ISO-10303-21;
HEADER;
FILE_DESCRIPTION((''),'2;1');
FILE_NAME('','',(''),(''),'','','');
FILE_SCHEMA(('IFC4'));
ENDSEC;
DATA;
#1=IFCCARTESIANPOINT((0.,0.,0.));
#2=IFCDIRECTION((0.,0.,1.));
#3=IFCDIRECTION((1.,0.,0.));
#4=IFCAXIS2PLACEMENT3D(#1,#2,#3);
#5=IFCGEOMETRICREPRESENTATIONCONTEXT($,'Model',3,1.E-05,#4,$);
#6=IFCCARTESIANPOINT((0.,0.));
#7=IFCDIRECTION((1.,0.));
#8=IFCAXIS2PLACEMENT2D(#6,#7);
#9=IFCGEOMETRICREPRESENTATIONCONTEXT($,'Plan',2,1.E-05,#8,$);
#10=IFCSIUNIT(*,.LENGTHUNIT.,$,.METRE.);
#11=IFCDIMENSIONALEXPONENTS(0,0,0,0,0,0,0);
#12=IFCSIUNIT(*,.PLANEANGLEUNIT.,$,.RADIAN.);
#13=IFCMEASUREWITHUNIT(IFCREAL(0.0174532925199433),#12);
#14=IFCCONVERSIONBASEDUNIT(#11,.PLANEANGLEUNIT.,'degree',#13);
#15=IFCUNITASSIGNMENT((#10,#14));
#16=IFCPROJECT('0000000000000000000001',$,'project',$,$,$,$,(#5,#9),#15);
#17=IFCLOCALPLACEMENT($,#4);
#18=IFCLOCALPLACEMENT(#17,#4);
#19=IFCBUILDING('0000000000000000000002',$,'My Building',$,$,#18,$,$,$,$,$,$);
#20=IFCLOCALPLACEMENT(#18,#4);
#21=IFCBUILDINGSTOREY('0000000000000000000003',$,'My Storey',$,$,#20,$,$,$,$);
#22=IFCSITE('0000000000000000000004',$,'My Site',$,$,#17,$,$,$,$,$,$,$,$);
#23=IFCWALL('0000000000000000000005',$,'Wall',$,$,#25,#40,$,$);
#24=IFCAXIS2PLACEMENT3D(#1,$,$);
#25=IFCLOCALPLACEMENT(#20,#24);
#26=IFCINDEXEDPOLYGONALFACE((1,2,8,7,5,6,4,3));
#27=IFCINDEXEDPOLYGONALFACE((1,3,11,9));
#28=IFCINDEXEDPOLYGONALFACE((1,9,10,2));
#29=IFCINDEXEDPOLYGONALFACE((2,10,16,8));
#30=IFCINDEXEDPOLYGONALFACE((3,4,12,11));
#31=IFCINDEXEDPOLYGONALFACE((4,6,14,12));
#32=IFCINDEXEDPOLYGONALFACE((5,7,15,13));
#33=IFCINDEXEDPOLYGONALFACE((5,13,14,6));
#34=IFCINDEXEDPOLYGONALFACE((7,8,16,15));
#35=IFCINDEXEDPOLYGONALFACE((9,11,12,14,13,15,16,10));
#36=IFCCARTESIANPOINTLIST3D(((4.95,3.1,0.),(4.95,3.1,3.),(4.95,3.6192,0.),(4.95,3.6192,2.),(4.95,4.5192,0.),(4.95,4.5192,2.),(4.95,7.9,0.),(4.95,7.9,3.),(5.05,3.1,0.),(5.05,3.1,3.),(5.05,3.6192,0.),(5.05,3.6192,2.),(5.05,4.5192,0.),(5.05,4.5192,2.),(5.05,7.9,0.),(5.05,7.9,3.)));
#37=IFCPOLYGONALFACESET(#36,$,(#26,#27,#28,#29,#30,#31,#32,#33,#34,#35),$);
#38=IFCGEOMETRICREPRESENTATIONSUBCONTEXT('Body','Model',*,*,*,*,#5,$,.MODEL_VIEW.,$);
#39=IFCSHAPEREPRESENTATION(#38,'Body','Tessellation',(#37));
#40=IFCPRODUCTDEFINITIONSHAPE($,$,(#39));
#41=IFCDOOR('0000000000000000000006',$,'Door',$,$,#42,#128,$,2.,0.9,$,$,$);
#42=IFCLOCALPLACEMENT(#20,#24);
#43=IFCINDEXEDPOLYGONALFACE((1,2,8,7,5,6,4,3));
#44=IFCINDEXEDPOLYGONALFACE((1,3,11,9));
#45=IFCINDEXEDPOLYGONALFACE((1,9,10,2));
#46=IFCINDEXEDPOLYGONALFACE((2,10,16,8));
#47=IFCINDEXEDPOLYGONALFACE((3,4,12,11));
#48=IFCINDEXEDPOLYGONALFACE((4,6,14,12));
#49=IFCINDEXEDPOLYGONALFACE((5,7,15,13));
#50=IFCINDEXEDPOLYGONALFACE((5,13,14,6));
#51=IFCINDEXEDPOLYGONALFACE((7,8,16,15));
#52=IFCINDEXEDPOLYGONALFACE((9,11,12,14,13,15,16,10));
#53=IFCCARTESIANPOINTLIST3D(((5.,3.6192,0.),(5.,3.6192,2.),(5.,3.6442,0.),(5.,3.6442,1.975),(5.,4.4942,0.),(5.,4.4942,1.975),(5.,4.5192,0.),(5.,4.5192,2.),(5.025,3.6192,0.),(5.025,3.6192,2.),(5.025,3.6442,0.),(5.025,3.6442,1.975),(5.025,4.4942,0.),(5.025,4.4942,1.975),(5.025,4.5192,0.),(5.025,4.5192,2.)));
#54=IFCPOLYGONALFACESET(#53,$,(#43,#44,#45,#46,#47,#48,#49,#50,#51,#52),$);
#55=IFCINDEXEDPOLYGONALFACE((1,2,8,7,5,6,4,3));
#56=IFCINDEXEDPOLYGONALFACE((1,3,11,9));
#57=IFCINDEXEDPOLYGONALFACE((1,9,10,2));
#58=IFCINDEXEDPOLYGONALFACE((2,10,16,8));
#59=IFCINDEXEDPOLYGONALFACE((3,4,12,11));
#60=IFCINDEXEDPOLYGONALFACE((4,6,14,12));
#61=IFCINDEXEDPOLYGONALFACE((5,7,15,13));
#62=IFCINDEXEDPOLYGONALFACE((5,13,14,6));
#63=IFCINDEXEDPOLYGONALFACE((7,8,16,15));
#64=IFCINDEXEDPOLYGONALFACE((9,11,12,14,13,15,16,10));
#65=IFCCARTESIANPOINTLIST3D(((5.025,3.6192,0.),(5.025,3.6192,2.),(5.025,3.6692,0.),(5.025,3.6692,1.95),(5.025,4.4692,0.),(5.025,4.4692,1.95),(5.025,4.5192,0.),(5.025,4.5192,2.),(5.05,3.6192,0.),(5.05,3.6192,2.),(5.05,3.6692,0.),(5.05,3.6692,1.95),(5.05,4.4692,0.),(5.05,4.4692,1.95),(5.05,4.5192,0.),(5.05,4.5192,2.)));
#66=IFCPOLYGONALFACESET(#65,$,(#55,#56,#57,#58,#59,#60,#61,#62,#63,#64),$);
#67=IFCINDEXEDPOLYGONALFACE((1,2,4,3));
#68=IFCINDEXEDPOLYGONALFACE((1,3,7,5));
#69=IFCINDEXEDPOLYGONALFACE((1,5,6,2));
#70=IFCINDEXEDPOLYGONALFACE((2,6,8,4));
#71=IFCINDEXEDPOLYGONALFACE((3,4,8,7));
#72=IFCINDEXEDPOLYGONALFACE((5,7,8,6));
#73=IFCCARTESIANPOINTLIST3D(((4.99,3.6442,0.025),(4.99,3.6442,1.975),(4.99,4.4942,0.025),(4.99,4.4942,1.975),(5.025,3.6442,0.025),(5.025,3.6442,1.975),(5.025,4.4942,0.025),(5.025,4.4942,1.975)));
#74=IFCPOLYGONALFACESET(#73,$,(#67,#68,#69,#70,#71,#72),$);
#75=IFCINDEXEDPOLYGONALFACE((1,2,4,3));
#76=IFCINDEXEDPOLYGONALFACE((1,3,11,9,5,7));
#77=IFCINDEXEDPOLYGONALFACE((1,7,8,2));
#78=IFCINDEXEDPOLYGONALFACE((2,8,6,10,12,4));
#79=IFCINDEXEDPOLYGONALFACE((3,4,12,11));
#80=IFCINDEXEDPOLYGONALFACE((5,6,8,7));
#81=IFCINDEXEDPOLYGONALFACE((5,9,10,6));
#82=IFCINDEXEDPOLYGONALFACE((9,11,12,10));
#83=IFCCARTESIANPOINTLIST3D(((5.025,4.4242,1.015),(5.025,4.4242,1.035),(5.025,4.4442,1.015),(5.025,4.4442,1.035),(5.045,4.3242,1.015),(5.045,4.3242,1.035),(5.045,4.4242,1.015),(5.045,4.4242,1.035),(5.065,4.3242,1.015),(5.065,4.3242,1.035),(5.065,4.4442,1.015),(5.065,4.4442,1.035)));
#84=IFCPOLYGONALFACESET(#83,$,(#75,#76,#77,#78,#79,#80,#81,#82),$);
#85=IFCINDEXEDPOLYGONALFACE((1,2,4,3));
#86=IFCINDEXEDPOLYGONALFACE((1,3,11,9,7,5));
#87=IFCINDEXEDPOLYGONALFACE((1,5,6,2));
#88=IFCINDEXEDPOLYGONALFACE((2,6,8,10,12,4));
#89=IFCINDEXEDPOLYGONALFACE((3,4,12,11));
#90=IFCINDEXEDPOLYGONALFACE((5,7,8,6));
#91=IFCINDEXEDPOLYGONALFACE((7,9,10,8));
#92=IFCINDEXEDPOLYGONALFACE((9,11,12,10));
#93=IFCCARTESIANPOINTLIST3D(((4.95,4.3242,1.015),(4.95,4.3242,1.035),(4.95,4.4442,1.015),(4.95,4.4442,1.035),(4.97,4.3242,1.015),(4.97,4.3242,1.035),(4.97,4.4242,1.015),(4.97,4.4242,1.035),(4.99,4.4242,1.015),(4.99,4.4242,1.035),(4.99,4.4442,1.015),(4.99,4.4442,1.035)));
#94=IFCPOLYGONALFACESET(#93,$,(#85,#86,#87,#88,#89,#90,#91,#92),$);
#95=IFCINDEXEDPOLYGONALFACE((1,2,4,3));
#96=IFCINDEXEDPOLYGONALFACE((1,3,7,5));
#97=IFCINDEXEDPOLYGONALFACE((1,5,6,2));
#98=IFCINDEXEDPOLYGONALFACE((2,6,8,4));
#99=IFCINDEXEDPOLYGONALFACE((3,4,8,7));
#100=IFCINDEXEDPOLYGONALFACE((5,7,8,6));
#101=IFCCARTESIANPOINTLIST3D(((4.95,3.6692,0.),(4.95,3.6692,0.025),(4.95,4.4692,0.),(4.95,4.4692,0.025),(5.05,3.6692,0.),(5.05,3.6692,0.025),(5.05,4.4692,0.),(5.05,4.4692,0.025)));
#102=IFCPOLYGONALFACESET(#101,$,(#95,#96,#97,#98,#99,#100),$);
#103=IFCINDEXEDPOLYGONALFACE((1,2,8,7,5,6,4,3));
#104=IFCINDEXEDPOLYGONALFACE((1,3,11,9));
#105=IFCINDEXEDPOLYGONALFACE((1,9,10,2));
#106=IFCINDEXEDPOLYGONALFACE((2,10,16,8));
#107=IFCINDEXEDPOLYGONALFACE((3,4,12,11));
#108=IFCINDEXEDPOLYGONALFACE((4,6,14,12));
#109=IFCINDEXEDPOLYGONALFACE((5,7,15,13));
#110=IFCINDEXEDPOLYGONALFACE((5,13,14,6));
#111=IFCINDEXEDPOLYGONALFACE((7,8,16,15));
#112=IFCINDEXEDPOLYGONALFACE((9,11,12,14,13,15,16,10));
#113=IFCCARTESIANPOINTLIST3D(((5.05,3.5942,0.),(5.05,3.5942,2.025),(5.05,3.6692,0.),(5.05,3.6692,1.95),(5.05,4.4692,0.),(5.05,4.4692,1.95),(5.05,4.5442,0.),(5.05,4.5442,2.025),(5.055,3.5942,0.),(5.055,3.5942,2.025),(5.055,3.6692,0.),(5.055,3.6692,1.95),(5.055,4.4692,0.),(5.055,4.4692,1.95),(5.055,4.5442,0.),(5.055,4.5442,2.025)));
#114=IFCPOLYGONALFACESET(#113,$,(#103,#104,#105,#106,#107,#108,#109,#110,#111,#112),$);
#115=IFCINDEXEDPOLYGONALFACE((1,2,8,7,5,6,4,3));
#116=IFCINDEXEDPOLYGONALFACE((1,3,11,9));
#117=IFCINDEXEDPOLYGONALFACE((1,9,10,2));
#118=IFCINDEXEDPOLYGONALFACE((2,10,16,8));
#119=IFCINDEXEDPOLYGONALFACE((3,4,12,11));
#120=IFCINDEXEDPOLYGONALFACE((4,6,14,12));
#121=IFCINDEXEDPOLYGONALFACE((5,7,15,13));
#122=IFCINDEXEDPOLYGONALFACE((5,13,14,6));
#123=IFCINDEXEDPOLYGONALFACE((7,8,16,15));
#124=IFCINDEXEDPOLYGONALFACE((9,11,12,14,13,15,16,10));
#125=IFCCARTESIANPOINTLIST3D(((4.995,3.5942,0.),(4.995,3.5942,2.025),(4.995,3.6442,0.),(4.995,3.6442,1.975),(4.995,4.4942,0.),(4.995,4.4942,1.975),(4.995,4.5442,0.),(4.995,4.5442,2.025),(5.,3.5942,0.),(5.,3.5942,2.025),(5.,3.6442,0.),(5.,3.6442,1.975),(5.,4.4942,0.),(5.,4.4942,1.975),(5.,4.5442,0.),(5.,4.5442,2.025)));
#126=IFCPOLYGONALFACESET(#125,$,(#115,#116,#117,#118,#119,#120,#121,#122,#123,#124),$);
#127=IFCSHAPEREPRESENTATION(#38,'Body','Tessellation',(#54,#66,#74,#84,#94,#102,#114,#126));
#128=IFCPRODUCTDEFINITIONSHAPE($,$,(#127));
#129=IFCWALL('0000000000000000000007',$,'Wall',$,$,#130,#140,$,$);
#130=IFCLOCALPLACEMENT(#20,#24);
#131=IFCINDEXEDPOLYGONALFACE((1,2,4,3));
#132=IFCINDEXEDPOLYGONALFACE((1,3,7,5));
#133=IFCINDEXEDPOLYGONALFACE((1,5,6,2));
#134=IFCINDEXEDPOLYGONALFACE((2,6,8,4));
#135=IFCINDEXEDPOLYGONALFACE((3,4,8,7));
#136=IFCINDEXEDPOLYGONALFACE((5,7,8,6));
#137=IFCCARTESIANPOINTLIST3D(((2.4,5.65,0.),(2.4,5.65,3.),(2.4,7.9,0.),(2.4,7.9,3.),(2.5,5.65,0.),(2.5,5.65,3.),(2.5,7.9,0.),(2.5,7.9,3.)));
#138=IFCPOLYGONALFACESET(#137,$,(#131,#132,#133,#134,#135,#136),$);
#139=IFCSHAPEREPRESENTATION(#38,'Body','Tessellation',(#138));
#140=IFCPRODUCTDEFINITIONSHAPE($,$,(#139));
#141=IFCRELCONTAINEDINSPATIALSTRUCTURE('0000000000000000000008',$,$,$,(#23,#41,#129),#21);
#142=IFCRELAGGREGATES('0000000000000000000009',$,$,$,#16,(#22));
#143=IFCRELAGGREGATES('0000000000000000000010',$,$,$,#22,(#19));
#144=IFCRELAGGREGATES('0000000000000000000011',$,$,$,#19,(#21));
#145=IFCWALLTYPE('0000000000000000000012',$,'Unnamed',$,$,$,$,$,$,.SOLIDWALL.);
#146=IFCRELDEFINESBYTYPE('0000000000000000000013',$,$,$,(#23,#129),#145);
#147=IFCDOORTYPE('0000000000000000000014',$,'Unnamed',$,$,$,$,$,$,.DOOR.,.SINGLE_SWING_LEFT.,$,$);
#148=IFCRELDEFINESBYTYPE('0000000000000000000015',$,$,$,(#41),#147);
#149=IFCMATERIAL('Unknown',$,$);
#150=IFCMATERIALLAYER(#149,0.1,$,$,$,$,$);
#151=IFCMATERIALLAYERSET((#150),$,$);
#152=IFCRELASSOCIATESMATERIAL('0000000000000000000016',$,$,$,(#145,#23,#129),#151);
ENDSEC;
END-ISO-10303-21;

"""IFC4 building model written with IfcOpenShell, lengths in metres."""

from ifc_helpers import new_model, entity, si_unit, converted_unit, frame, origin_with_axes, origin_2d_with_axis, place, context, subcontext, project, spatial, line, indexed_curve, outline, extrude, shape, source, transform, mapped, material, layer, layer_set, layer_usage, type_object, type_shapes, element, fill, save


model = new_model("IFC4")

# Units and contexts
model_context = context("Model", 3, precision=1e-05, world=origin_with_axes())
plan_context = context("Plan", 2, precision=1e-05, world=origin_2d_with_axis())
body_context_1 = subcontext(model_context, "Body", "Model", "MODEL_VIEW")
body_context_2 = subcontext(plan_context, "Body", "Plan", "PLAN_VIEW")
ifc_project = project(units=[si_unit("LENGTHUNIT", "METRE"), converted_unit("PLANEANGLEUNIT", "degree", entity("IfcReal", 0.0174532925199433), si_unit("PLANEANGLEUNIT", "RADIAN"), dimensions=[0, 0, 0, 0, 0, 0, 0])], contexts=[model_context, plan_context])

# Site, building, storey
site_placement = place(None, origin_with_axes())
site = spatial("IfcSite", under=ifc_project, at=site_placement, Name="My Site")
building_placement = place(site_placement, origin_with_axes())
building = spatial("IfcBuilding", under=site, at=building_placement, Name="My Building")
storey_placement = place(building_placement, origin_with_axes())
storey = spatial("IfcBuildingStorey", under=building, at=storey_placement, Name="My Storey")

# Shared definitions
ifc_material = material(Name="Unknown")

# Shared definitions
ifc_layer = layer(ifc_material, 0.1)
ifc_layer_set = layer_set([ifc_layer])
wall_type = type_object("IfcWallType", Name="Unnamed", PredefinedType="SOLIDWALL", material=ifc_layer_set)
shared_shape_1 = source(origin_with_axes(), body_context_1, "Body", "SweptSolid", [
    extrude(outline(indexed_curve([(0.0, 0.0), (0.9, 0.0), (0.9, 2.0), (0.0, 2.0)], segments=[line(1, 2, 3, 4, 1)])), frame((0.0, -0.6, 0.0), z_axis=(0.0, -1.0, 0.0), x_axis=(1.0, 0.0, 0.0)), (0.0, 0.0, -1.0), 1.2),
])
door_type = type_object("IfcDoorType", Name="Unnamed", OperationType="SINGLE_SWING_LEFT", PredefinedType="DOOR")
shared_shape_2 = source(origin_with_axes(), body_context_1, "Body", "SweptSolid", [
    extrude(outline(indexed_curve([(0.0, 0.0), (0.0, 2.0), (0.9, 2.0), (0.9, 0.0), (0.875, 0.0), (0.875, 1.975), (0.025, 1.975), (0.025, 0.0)], segments=[line(1, 2, 3, 4, 5, 6, 7, 8, 1)])), frame((0.0, 0.025, 0.0), z_axis=(0.0, -1.0, 0.0), x_axis=(1.0, 0.0, 0.0)), (0.0, 0.0, -1.0), 0.025),
    extrude(outline(indexed_curve([(0.0, 0.0), (0.0, 2.0), (0.9, 2.0), (0.9, 0.0), (0.85, 0.0), (0.85, 1.95), (0.05, 1.95), (0.05, 0.0)], segments=[line(1, 2, 3, 4, 5, 6, 7, 8, 1)])), frame((0.0, 0.0, 0.0), z_axis=(0.0, -1.0, 0.0), x_axis=(1.0, 0.0, 0.0)), (0.0, 0.0, -1.0), 0.025),
    extrude(outline(indexed_curve([(0.0, 0.0), (0.85, 0.0), (0.85, 0.035), (0.0, 0.035)], segments=[line(1, 2, 3, 4, 1)])), frame((0.025, 0.025, 0.025), z_axis=(0.0, 0.0, 1.0), x_axis=(1.0, 0.0, 0.0)), (0.0, 0.0, 1.0), 1.95),
    extrude(outline(indexed_curve([(0.0, 0.0), (0.0, -0.04), (-0.12, -0.04), (-0.12, -0.02), (-0.02, -0.02), (-0.02, 0.0)], segments=[line(1, 2, 3, 4, 5, 6, 1)])), frame((0.825, 0.025, 1.015), z_axis=(0.0, 0.0, 1.0), x_axis=(1.0, 0.0, 0.0)), (0.0, 0.0, 1.0), 0.02),
    extrude(outline(indexed_curve([(0.0, 0.0), (0.0, 0.04), (-0.12, 0.04), (-0.12, 0.02), (-0.02, 0.02), (-0.02, 0.0)], segments=[line(1, 2, 3, 4, 5, 6, 1)])), frame((0.825, 0.06, 1.015), z_axis=(0.0, 0.0, 1.0), x_axis=(1.0, 0.0, 0.0)), (0.0, 0.0, 1.0), 0.02),
    extrude(outline(indexed_curve([(0.0, 0.0), (0.8, 0.0), (0.8, 0.1), (0.0, 0.1)], segments=[line(1, 2, 3, 4, 1)])), frame((0.05, 0.0, 0.0), z_axis=(0.0, 0.0, 1.0), x_axis=(1.0, 0.0, 0.0)), (0.0, 0.0, 1.0), 0.025),
    extrude(outline(indexed_curve([(0.0, 0.0), (0.0, 2.025), (0.95, 2.025), (0.95, 0.0), (0.875, 0.0), (0.875, 1.95), (0.075, 1.95), (0.075, 0.0)], segments=[line(1, 2, 3, 4, 5, 6, 7, 8, 1)])), frame((-0.025, -0.005, 0.0), z_axis=(0.0, -1.0, 0.0), x_axis=(1.0, 0.0, 0.0)), (0.0, 0.0, -1.0), 0.005),
    extrude(outline(indexed_curve([(0.0, 0.0), (0.0, 2.025), (0.95, 2.025), (0.95, 0.0), (0.9, 0.0), (0.9, 1.975), (0.05, 1.975), (0.05, 0.0)], segments=[line(1, 2, 3, 4, 5, 6, 7, 8, 1)])), frame((-0.025, 0.05, 0.0), z_axis=(0.0, -1.0, 0.0), x_axis=(1.0, 0.0, 0.0)), (0.0, 0.0, -1.0), 0.005),
])
shared_shape_3 = source(origin_with_axes(), body_context_2, "Body", "Curve2D", [
    entity("IfcIndexedPolyCurve", entity("IfcCartesianPointList2D", [[0.0, 0.0], [0.0, 0.05], [0.025, 0.05], [0.025, 0.025], [0.05, 0.025], [0.05, 0.0]]), [entity("IfcLineIndex", [1, 2, 3, 4, 5, 6, 1])]),
    entity("IfcIndexedPolyCurve", entity("IfcCartesianPointList2D", [[0.9, 0.0], [0.9, 0.05], [0.875, 0.05], [0.875, 0.025], [0.85, 0.025], [0.85, 0.0]]), [entity("IfcLineIndex", [1, 2, 3, 4, 5, 6, 1])]),
    entity("IfcTrimmedCurve", entity("IfcEllipse", entity("IfcAxis2Placement2D", entity("IfcCartesianPoint", [0.06, 0.05]), entity("IfcDirection", [1.0, 0.0])), 0.815, 0.85), [entity("IfcCartesianPoint", [0.875, 0.05])], [entity("IfcCartesianPoint", [0.06, 0.9])], True, "CARTESIAN"),
    entity("IfcIndexedPolyCurve", entity("IfcCartesianPointList2D", [[0.025, 0.05], [0.06, 0.05], [0.06, 0.9], [0.025, 0.9]]), [entity("IfcLineIndex", [1, 2, 3, 4, 1])]),
])
type_shapes(door_type, [shared_shape_2, shared_shape_3])

# Wall, opening, door
ifc_layer_usage_1 = layer_usage(ifc_layer_set, "AXIS2", "POSITIVE", 0.0)
wall_1_placement = place(storey_placement, frame((5.05, 3.1, 0.0), z_axis=(0.0, 0.0, 1.0), x_axis=(0.0, 1.0, 0.0)))
wall_1 = element("IfcWall", 1, at=wall_1_placement, inside=storey, type_object=wall_type, material=ifc_layer_usage_1, Name="Wall", context=body_context_1, shape_type="SweptSolid", body=[
    extrude(outline(indexed_curve([(0.0, 0.0), (0.0, 0.1), (4.8, 0.1), (4.8, 0.0)], segments=[line(1, 2, 3, 4, 1)])), origin_with_axes(), (0.0, 0.0, 1.0), 3.0),
])
opening_1_placement = place(wall_1_placement, frame((0.5192, 0.0, 0.0), z_axis=(0.0, 0.0, 1.0), x_axis=(1.0, 0.0, 0.0)))
opening_1 = element("IfcOpeningElement", 2, at=opening_1_placement, cuts=wall_1, PredefinedType="OPENING", context=body_context_1, shape_type="MappedRepresentation", body=[
    mapped(shared_shape_1, transform((0.0, 0.0, 0.0), x_axis=(1.0, 0.0, 0.0), y_axis=(0.0, 1.0, 0.0), z_axis=(0.0, 0.0, 1.0), scale=1.0)),
])
door_1_placement = place(opening_1_placement, origin_with_axes())
door_1 = element("IfcDoor", 3, at=door_1_placement, inside=storey, type_object=door_type, Name="Door", OverallHeight=2.0, OverallWidth=0.9, shapes=[
    shape(body_context_1, "Body", "MappedRepresentation", [mapped(shared_shape_2, transform((0.0, 0.0, 0.0), x_axis=(1.0, 0.0, 0.0), y_axis=(0.0, 1.0, 0.0), z_axis=(0.0, 0.0, 1.0), scale=1.0))]),
    shape(body_context_2, "Body", "MappedRepresentation", [mapped(shared_shape_3, transform((0.0, 0.0, 0.0), x_axis=(1.0, 0.0, 0.0), y_axis=(0.0, 1.0, 0.0), z_axis=(0.0, 0.0, 1.0), scale=1.0))]),
])
fill(opening_1, door_1)

# Wall
ifc_layer_usage_2 = layer_usage(ifc_layer_set, "AXIS2", "POSITIVE", 0.0)
wall_2_placement = place(storey_placement, frame((2.5, 5.65, 0.0), z_axis=(0.0, 0.0, 1.0), x_axis=(0.0, 1.0, 0.0)))
element("IfcWall", 4, at=wall_2_placement, inside=storey, type_object=wall_type, material=ifc_layer_usage_2, Name="Wall", context=body_context_1, shape_type="SweptSolid", body=[
    extrude(outline(indexed_curve([(0.0, 0.0), (0.0, 0.1), (2.25, 0.1), (2.25, 0.0)], segments=[line(1, 2, 3, 4, 1)])), origin_with_axes(), (0.0, 0.0, 1.0), 3.0),
])

save(model, "model.ifc")
